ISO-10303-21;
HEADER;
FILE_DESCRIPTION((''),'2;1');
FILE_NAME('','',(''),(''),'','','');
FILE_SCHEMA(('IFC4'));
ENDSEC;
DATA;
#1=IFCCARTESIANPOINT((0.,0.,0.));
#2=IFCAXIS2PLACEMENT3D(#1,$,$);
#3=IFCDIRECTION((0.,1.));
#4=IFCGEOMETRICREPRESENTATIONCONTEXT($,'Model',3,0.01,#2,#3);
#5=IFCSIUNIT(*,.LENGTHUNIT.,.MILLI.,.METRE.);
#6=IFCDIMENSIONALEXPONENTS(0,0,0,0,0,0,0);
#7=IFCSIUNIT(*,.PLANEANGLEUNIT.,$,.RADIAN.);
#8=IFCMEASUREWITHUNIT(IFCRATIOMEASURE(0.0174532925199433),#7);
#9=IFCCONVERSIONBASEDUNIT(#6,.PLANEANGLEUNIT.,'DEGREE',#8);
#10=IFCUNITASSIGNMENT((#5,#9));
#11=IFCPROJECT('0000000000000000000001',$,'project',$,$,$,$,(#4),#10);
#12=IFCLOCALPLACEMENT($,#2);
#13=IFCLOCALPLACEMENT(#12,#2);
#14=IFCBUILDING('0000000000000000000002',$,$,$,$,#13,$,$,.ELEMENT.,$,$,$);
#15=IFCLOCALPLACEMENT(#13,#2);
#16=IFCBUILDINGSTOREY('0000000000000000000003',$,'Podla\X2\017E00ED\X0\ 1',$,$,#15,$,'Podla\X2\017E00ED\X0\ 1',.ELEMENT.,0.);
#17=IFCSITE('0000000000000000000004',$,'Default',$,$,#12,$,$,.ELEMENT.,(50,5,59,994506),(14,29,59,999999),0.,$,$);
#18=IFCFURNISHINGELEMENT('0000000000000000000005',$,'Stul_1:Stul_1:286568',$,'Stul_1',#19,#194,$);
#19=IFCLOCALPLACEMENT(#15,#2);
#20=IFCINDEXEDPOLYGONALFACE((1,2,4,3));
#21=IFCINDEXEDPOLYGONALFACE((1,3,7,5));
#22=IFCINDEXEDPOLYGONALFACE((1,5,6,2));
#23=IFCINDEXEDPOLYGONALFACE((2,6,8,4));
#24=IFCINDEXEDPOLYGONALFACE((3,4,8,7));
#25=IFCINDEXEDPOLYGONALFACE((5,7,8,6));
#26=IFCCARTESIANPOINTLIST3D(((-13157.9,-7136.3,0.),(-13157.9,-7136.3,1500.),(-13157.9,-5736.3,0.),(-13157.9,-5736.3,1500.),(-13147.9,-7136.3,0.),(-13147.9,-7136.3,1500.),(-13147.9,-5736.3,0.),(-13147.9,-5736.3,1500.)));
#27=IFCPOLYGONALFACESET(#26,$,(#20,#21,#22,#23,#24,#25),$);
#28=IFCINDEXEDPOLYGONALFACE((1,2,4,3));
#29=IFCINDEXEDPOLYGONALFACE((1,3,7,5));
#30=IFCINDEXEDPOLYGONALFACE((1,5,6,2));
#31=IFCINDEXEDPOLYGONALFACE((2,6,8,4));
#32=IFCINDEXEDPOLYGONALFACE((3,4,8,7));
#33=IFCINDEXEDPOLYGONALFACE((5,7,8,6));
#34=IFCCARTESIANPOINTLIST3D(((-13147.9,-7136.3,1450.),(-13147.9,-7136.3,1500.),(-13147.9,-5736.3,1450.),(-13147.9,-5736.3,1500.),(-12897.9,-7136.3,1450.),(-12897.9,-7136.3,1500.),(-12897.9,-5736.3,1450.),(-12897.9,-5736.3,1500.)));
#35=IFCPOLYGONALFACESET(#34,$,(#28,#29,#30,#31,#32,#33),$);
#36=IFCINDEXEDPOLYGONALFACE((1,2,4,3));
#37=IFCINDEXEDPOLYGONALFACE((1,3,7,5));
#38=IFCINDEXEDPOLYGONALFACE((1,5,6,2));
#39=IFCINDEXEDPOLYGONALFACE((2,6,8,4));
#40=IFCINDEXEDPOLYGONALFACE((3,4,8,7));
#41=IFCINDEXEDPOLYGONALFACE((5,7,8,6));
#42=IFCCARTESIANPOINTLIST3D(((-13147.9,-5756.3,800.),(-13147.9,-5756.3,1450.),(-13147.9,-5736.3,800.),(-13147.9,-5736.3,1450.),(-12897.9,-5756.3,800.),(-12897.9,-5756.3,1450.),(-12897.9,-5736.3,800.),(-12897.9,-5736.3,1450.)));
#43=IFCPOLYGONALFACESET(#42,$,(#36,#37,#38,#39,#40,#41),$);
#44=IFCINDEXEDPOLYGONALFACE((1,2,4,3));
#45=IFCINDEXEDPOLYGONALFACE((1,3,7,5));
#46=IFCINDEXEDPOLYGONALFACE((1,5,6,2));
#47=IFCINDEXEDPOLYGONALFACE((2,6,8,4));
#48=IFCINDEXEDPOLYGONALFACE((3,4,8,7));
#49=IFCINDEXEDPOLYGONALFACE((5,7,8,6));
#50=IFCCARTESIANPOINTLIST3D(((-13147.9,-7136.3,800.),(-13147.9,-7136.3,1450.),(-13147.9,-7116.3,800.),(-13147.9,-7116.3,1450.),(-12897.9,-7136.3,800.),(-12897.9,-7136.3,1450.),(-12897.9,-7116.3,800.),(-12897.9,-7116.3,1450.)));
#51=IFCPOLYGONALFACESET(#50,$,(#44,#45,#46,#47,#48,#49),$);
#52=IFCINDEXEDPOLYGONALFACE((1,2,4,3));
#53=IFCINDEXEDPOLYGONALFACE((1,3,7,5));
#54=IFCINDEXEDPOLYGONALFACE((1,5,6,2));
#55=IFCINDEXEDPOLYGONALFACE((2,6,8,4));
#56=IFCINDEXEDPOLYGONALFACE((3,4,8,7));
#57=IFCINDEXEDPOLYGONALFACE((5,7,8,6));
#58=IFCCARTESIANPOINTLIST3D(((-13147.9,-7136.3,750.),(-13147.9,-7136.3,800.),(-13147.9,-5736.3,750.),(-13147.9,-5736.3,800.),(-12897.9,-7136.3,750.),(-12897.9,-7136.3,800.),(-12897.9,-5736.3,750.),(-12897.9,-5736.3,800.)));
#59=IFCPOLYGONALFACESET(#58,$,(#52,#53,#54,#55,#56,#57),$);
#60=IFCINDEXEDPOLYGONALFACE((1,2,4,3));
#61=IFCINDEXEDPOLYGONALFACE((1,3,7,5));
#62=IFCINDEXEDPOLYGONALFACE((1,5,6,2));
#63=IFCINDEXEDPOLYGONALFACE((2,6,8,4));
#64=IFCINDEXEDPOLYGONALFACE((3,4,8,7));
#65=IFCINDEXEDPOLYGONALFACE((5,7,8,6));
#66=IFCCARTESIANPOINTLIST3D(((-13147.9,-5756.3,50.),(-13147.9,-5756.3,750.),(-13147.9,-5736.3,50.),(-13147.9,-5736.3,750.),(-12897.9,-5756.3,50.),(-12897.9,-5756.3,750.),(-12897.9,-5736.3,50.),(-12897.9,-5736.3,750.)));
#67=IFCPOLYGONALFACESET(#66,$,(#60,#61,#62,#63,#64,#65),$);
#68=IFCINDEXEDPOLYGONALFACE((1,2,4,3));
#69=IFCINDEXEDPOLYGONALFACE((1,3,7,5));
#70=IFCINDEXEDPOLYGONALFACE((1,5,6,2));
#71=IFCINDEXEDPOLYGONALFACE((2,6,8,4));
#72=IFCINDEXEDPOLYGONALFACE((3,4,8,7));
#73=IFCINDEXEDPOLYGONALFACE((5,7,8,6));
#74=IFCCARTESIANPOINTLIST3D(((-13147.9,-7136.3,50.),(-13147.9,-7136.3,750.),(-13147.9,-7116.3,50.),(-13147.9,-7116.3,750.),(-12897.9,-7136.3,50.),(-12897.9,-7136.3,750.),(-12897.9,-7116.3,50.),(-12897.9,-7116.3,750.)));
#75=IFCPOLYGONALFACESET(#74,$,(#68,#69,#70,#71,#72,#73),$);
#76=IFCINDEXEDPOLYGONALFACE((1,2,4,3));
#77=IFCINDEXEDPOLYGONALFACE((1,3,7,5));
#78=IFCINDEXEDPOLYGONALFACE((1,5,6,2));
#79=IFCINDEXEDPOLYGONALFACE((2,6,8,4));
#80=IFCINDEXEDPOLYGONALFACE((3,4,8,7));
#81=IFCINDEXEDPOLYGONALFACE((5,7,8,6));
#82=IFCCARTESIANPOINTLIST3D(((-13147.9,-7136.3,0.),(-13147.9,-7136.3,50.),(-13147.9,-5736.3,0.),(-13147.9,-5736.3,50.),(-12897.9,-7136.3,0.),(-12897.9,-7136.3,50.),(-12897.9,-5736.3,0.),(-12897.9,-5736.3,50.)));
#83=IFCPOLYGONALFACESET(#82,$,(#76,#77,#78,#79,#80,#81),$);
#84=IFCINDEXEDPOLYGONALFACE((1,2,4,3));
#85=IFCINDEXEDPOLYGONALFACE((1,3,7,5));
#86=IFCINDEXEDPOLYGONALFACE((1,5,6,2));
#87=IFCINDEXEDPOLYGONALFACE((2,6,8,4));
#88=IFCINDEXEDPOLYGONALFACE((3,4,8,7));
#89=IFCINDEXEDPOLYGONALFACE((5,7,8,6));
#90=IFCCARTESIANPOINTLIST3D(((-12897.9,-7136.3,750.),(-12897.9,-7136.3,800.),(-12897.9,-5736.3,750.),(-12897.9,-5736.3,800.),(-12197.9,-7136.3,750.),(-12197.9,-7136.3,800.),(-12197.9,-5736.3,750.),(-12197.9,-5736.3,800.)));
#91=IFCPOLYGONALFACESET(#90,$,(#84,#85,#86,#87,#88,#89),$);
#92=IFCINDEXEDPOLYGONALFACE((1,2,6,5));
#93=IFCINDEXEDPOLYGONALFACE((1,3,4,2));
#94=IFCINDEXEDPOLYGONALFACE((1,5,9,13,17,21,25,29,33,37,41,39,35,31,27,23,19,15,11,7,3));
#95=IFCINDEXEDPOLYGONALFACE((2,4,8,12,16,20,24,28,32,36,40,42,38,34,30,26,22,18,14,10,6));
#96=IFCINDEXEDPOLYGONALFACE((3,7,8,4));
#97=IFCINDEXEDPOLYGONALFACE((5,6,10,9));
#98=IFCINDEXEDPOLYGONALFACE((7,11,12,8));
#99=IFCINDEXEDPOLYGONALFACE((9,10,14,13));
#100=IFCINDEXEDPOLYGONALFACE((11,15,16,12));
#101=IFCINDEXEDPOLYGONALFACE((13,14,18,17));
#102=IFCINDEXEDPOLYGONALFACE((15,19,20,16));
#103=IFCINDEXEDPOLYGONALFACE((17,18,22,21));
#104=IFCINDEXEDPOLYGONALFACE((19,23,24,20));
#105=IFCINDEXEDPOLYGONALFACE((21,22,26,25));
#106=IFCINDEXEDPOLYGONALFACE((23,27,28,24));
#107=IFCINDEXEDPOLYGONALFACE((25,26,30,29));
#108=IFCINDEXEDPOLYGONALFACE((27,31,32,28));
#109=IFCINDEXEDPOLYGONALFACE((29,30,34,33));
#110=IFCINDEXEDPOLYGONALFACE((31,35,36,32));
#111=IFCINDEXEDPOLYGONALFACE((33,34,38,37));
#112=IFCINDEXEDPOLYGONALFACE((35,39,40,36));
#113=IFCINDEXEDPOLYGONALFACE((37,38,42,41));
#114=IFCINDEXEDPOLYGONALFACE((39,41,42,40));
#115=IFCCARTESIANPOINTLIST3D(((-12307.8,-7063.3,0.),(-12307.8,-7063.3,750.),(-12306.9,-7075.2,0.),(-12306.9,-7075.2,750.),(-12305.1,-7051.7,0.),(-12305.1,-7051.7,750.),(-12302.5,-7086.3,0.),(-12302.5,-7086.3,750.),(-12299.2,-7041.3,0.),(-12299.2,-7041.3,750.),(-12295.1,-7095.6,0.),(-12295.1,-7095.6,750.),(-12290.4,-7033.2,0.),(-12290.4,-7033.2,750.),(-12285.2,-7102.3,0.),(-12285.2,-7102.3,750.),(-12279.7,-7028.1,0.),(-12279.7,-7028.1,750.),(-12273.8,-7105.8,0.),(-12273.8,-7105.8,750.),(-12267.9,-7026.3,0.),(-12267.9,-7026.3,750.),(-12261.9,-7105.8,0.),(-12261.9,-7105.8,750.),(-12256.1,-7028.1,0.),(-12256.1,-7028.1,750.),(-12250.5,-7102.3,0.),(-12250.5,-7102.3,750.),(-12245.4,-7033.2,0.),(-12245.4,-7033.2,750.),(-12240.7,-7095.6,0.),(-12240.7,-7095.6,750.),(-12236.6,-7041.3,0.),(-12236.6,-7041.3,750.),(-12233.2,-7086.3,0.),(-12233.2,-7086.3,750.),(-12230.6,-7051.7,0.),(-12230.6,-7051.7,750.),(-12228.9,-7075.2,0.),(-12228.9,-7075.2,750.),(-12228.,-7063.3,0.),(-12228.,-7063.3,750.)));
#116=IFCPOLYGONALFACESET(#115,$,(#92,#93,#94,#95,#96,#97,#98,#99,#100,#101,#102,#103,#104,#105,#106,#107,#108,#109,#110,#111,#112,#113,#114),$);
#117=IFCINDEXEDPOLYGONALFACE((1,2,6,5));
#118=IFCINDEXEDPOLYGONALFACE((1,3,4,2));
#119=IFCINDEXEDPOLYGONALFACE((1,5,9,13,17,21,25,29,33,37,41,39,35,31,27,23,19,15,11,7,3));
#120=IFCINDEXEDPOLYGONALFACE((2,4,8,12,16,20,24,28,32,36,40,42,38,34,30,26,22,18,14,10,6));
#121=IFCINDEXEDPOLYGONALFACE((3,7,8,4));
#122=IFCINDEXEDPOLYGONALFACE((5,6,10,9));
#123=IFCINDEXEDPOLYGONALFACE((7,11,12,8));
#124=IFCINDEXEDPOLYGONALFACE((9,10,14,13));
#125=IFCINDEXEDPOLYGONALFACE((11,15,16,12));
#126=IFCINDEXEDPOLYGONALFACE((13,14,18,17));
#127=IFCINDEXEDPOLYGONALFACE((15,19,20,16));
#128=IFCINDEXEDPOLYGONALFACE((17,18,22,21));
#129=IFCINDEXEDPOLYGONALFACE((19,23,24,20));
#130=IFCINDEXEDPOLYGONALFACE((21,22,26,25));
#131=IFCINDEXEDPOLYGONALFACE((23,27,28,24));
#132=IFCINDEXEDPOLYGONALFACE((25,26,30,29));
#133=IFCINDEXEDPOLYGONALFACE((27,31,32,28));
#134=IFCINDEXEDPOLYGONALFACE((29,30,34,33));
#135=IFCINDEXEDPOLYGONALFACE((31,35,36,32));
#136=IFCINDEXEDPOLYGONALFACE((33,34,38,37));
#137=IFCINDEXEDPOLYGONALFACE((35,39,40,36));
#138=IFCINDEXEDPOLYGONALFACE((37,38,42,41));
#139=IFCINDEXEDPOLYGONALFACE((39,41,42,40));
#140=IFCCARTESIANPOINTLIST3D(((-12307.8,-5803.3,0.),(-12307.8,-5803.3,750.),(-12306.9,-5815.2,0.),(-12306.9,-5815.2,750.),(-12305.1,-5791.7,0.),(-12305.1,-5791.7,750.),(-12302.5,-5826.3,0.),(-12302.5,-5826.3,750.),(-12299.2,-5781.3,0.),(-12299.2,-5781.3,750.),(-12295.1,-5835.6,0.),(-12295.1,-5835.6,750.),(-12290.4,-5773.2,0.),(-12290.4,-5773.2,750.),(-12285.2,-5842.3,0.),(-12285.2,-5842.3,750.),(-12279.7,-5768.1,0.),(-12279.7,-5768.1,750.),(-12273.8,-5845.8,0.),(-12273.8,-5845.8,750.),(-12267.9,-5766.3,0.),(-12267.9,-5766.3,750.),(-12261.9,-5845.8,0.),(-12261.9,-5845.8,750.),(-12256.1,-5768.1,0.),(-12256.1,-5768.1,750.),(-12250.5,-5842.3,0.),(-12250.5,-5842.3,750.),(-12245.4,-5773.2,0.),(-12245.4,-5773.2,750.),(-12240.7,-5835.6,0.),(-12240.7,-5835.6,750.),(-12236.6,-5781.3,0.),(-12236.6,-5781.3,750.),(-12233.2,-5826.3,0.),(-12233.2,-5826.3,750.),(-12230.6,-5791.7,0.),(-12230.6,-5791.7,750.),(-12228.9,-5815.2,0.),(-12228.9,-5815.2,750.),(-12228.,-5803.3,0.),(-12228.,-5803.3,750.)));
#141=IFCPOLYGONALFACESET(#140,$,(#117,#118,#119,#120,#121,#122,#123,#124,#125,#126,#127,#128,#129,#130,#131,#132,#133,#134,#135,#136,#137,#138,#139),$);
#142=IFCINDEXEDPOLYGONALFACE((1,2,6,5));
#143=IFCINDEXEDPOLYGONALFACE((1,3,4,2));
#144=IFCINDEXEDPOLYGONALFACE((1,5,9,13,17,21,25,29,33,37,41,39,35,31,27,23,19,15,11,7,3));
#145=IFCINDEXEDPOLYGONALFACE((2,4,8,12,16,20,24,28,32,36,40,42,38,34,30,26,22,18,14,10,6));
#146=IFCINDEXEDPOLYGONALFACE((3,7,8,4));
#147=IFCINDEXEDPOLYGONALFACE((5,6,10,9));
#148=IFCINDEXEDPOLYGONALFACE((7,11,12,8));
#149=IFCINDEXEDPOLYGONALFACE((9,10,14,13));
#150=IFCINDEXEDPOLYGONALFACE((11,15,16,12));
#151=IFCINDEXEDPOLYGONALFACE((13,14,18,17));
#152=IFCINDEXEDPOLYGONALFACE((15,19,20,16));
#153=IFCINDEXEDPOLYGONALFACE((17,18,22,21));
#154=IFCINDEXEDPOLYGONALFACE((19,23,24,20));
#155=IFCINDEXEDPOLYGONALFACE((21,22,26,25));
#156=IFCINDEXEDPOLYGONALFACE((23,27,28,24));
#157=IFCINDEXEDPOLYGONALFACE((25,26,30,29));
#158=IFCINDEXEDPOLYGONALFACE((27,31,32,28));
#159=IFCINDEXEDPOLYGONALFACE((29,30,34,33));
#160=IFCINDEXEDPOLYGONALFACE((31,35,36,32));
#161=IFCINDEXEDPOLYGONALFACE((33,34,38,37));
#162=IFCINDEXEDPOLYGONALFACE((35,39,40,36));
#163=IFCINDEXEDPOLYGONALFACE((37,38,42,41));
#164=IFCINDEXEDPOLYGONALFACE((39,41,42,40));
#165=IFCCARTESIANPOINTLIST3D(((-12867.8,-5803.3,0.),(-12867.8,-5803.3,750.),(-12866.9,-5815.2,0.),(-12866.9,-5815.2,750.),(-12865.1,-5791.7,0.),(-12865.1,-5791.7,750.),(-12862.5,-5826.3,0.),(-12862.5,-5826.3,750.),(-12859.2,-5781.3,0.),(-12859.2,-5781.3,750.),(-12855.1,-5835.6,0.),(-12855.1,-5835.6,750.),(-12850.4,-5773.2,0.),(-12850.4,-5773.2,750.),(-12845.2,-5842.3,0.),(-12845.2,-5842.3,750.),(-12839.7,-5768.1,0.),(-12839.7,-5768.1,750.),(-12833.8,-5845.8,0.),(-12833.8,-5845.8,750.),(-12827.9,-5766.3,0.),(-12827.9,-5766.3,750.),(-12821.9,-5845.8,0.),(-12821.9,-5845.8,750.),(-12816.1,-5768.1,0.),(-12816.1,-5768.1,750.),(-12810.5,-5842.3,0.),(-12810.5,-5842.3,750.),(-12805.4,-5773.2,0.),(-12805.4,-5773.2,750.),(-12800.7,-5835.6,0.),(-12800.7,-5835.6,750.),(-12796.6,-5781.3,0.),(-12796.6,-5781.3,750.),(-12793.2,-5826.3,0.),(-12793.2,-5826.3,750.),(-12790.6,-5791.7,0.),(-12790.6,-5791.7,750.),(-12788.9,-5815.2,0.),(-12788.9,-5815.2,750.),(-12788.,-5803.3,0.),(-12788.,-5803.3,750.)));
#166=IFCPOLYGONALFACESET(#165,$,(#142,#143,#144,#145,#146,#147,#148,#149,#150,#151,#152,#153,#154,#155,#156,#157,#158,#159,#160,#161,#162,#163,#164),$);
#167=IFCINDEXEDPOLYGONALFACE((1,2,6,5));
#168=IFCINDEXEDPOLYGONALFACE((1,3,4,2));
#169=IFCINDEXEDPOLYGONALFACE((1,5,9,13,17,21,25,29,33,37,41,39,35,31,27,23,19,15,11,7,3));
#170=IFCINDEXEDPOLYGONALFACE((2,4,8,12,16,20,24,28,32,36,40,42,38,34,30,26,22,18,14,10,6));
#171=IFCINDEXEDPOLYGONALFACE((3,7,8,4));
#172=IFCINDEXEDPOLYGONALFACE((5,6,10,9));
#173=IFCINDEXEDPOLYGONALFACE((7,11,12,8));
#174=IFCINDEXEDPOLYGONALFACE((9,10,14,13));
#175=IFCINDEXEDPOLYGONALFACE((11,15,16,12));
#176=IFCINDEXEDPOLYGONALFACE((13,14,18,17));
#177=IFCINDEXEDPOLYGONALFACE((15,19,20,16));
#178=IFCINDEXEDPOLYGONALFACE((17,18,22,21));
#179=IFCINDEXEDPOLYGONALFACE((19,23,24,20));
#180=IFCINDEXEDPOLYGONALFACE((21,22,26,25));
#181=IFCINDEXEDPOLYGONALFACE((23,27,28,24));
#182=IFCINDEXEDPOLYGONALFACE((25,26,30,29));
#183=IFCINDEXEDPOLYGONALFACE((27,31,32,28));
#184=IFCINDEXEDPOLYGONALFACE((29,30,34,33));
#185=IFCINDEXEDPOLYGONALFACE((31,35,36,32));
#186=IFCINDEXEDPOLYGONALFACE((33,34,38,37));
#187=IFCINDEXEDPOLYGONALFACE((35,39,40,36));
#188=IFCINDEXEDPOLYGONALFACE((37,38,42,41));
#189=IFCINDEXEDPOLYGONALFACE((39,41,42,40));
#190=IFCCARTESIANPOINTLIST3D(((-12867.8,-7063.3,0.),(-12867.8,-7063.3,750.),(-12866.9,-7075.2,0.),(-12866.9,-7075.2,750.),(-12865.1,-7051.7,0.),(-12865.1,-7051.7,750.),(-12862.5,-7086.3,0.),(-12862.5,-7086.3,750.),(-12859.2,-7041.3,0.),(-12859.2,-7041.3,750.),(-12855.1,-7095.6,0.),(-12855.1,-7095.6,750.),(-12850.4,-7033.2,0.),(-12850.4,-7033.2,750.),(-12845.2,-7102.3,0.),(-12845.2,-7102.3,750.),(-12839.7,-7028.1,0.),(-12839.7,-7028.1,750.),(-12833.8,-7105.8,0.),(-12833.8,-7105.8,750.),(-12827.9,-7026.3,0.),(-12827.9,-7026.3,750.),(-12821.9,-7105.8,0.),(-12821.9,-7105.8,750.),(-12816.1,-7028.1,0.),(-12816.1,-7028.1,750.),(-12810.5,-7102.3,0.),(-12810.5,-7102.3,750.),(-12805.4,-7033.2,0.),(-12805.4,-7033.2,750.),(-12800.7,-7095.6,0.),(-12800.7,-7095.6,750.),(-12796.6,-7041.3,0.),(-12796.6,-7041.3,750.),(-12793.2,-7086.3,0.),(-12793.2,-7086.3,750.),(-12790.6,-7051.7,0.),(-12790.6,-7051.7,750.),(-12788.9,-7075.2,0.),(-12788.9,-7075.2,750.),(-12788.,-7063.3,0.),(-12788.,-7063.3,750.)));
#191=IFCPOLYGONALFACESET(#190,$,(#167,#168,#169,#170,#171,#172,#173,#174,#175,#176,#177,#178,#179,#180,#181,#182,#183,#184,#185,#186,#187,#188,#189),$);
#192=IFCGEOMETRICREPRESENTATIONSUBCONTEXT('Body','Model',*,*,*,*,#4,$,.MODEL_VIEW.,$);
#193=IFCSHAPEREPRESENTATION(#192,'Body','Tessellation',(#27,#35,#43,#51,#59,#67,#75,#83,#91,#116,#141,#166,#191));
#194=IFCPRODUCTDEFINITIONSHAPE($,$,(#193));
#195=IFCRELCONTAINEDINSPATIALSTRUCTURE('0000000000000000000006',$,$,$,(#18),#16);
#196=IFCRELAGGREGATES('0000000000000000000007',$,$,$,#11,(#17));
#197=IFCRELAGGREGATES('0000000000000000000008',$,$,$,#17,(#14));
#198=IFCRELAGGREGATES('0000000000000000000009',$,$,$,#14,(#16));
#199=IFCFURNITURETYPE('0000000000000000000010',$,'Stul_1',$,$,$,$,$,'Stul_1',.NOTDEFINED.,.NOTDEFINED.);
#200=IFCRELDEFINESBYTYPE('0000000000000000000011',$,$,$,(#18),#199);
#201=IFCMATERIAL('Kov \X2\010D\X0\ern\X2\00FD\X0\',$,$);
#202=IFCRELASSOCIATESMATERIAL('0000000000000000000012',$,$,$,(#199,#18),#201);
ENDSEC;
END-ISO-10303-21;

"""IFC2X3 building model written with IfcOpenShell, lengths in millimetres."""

from ifc_helpers import new_model, entity, si_unit, converted_unit, direction, frame, frame_2d, origin, origin_2d_with_axis, place, context, subcontext, project, spatial, rectangle, circle, extrude, source, transform, mapped, material, type_object, type_shapes, element, save


model = new_model("IFC2X3")

# Units and contexts
model_context = context("Model", 3, precision=0.01, world=origin(), true_north=direction((0.0, 1.0)))
body_context = subcontext(model_context, "Body", "Model", "MODEL_VIEW")
ifc_project = project(units=[si_unit("LENGTHUNIT", "METRE", prefix="MILLI"), converted_unit("PLANEANGLEUNIT", "DEGREE", entity("IfcRatioMeasure", 0.0174532925199433), si_unit("PLANEANGLEUNIT", "RADIAN"), dimensions=[0, 0, 0, 0, 0, 0, 0])], contexts=[model_context])

# Site, building, storey
site_placement = place(None, origin())
site = spatial("IfcSite", under=ifc_project, at=site_placement, Name="Default", CompositionType="ELEMENT", RefLatitude=(50, 5, 59, 994506), RefLongitude=(14, 29, 59, 999999), RefElevation=0.0)
building_placement = place(site_placement, origin())
building = spatial("IfcBuilding", under=site, at=building_placement, CompositionType="ELEMENT")
storey_placement = place(building_placement, origin())
storey = spatial("IfcBuildingStorey", under=building, at=storey_placement, Name="Podlaží 1", LongName="Podlaží 1", CompositionType="ELEMENT", Elevation=0.0)

# Furnishing element
ifc_material_1 = material(Name="Kov černý")
furniture_type = type_object("IfcFurnitureType", Name="Stul_1", ElementType="Stul_1", material=ifc_material_1)
shared_shape_1 = source(origin(), body_context, "Body", "SweptSolid", [
    extrude(rectangle(XDim=1400.0, YDim=10.0, at=origin_2d_with_axis()), frame((0.0, 605.0, 0.0), z_axis=(0.0, 0.0, 1.0), x_axis=(-1.0, 0.0, 0.0)), (0.0, 0.0, 1.0), 1500.0),
    extrude(rectangle(XDim=1400.0, YDim=250.0, at=frame_2d((0.0, 0.0), x_axis=(1.0, 0.0))), frame((0.0, 475.0, 1450.0), z_axis=(0.0, 0.0, 1.0), x_axis=(-1.0, 0.0, 0.0)), (0.0, 0.0, 1.0), 50.0),
    extrude(rectangle(XDim=20.0, YDim=250.0, at=origin_2d_with_axis()), frame((690.0, 475.0, 800.0), z_axis=(0.0, 0.0, 1.0), x_axis=(-1.0, 0.0, 0.0)), (0.0, 0.0, 1.0), 650.0),
    extrude(rectangle(XDim=20.0, YDim=250.0, at=frame_2d((0.0, 0.0), x_axis=(1.0, 0.0))), frame((-690.0, 475.0, 800.0), z_axis=(0.0, 0.0, 1.0), x_axis=(-1.0, 0.0, 0.0)), (0.0, 0.0, 1.0), 650.0),
    extrude(rectangle(XDim=1400.0, YDim=250.0, at=origin_2d_with_axis()), frame((0.0, 475.0, 750.0), z_axis=(0.0, 0.0, 1.0), x_axis=(-1.0, 0.0, 0.0)), (0.0, 0.0, 1.0), 50.0),
    extrude(rectangle(XDim=20.0, YDim=250.0, at=origin_2d_with_axis()), frame((690.0, 475.0, 50.0), z_axis=(0.0, 0.0, 1.0), x_axis=(-1.0, 0.0, 0.0)), (0.0, 0.0, 1.0), 700.0),
    extrude(rectangle(XDim=20.0, YDim=250.0, at=frame_2d((0.0, 0.0), x_axis=(1.0, 0.0))), frame((-690.0, 475.0, 50.0), z_axis=(0.0, 0.0, 1.0), x_axis=(-1.0, 0.0, 0.0)), (0.0, 0.0, 1.0), 700.0),
    extrude(rectangle(XDim=1400.0, YDim=250.0, at=origin_2d_with_axis()), frame((0.0, 475.0, 0.0), z_axis=(0.0, 0.0, 1.0), x_axis=(-1.0, 0.0, 0.0)), (0.0, 0.0, 1.0), 50.0),
    extrude(rectangle(XDim=1400.0, YDim=700.0, at=origin_2d_with_axis()), frame((0.0, 0.0, 750.0), z_axis=(0.0, 0.0, 1.0), x_axis=(-1.0, 0.0, 0.0)), (0.0, 0.0, 1.0), 50.0),
    extrude(circle(Radius=40.0, at=frame_2d((0.0, 0.0), x_axis=(1.0, 0.0))), frame((-630.0, -280.0, 0.0)), (0.0, 0.0, 1.0), 750.0),
    extrude(circle(Radius=40.0, at=frame_2d((0.0, 0.0), x_axis=(1.0, 0.0))), frame((630.0, -280.0, 0.0)), (0.0, 0.0, 1.0), 750.0),
    extrude(circle(Radius=40.0, at=frame_2d((0.0, 0.0), x_axis=(1.0, 0.0))), frame((630.0, 280.0, 0.0)), (0.0, 0.0, 1.0), 750.0),
    extrude(circle(Radius=40.0, at=frame_2d((0.0, 0.0), x_axis=(1.0, 0.0))), frame((-630.0, 280.0, 0.0)), (0.0, 0.0, 1.0), 750.0),
])
type_shapes(furniture_type, [shared_shape_1])
for number, where, z_axis, x_axis, name in (
    (1, (-12547.9, -6436.3, 0.0), (0.0, 0.0, 1.0), (0.0, 1.0, 0.0), "Stul_1:Stul_1:286568"),
):
    element("IfcFurnishingElement", number, at=place(storey_placement, frame(where, z_axis=z_axis, x_axis=x_axis)), inside=storey, type_object=furniture_type, material=ifc_material_1, Name=name, ObjectType="Stul_1", context=body_context, shape_type="MappedRepresentation", body=[
        mapped(shared_shape_1, transform((0.0, 0.0, 0.0), scale=1.0)),
    ])

save(model, "model.ifc")
